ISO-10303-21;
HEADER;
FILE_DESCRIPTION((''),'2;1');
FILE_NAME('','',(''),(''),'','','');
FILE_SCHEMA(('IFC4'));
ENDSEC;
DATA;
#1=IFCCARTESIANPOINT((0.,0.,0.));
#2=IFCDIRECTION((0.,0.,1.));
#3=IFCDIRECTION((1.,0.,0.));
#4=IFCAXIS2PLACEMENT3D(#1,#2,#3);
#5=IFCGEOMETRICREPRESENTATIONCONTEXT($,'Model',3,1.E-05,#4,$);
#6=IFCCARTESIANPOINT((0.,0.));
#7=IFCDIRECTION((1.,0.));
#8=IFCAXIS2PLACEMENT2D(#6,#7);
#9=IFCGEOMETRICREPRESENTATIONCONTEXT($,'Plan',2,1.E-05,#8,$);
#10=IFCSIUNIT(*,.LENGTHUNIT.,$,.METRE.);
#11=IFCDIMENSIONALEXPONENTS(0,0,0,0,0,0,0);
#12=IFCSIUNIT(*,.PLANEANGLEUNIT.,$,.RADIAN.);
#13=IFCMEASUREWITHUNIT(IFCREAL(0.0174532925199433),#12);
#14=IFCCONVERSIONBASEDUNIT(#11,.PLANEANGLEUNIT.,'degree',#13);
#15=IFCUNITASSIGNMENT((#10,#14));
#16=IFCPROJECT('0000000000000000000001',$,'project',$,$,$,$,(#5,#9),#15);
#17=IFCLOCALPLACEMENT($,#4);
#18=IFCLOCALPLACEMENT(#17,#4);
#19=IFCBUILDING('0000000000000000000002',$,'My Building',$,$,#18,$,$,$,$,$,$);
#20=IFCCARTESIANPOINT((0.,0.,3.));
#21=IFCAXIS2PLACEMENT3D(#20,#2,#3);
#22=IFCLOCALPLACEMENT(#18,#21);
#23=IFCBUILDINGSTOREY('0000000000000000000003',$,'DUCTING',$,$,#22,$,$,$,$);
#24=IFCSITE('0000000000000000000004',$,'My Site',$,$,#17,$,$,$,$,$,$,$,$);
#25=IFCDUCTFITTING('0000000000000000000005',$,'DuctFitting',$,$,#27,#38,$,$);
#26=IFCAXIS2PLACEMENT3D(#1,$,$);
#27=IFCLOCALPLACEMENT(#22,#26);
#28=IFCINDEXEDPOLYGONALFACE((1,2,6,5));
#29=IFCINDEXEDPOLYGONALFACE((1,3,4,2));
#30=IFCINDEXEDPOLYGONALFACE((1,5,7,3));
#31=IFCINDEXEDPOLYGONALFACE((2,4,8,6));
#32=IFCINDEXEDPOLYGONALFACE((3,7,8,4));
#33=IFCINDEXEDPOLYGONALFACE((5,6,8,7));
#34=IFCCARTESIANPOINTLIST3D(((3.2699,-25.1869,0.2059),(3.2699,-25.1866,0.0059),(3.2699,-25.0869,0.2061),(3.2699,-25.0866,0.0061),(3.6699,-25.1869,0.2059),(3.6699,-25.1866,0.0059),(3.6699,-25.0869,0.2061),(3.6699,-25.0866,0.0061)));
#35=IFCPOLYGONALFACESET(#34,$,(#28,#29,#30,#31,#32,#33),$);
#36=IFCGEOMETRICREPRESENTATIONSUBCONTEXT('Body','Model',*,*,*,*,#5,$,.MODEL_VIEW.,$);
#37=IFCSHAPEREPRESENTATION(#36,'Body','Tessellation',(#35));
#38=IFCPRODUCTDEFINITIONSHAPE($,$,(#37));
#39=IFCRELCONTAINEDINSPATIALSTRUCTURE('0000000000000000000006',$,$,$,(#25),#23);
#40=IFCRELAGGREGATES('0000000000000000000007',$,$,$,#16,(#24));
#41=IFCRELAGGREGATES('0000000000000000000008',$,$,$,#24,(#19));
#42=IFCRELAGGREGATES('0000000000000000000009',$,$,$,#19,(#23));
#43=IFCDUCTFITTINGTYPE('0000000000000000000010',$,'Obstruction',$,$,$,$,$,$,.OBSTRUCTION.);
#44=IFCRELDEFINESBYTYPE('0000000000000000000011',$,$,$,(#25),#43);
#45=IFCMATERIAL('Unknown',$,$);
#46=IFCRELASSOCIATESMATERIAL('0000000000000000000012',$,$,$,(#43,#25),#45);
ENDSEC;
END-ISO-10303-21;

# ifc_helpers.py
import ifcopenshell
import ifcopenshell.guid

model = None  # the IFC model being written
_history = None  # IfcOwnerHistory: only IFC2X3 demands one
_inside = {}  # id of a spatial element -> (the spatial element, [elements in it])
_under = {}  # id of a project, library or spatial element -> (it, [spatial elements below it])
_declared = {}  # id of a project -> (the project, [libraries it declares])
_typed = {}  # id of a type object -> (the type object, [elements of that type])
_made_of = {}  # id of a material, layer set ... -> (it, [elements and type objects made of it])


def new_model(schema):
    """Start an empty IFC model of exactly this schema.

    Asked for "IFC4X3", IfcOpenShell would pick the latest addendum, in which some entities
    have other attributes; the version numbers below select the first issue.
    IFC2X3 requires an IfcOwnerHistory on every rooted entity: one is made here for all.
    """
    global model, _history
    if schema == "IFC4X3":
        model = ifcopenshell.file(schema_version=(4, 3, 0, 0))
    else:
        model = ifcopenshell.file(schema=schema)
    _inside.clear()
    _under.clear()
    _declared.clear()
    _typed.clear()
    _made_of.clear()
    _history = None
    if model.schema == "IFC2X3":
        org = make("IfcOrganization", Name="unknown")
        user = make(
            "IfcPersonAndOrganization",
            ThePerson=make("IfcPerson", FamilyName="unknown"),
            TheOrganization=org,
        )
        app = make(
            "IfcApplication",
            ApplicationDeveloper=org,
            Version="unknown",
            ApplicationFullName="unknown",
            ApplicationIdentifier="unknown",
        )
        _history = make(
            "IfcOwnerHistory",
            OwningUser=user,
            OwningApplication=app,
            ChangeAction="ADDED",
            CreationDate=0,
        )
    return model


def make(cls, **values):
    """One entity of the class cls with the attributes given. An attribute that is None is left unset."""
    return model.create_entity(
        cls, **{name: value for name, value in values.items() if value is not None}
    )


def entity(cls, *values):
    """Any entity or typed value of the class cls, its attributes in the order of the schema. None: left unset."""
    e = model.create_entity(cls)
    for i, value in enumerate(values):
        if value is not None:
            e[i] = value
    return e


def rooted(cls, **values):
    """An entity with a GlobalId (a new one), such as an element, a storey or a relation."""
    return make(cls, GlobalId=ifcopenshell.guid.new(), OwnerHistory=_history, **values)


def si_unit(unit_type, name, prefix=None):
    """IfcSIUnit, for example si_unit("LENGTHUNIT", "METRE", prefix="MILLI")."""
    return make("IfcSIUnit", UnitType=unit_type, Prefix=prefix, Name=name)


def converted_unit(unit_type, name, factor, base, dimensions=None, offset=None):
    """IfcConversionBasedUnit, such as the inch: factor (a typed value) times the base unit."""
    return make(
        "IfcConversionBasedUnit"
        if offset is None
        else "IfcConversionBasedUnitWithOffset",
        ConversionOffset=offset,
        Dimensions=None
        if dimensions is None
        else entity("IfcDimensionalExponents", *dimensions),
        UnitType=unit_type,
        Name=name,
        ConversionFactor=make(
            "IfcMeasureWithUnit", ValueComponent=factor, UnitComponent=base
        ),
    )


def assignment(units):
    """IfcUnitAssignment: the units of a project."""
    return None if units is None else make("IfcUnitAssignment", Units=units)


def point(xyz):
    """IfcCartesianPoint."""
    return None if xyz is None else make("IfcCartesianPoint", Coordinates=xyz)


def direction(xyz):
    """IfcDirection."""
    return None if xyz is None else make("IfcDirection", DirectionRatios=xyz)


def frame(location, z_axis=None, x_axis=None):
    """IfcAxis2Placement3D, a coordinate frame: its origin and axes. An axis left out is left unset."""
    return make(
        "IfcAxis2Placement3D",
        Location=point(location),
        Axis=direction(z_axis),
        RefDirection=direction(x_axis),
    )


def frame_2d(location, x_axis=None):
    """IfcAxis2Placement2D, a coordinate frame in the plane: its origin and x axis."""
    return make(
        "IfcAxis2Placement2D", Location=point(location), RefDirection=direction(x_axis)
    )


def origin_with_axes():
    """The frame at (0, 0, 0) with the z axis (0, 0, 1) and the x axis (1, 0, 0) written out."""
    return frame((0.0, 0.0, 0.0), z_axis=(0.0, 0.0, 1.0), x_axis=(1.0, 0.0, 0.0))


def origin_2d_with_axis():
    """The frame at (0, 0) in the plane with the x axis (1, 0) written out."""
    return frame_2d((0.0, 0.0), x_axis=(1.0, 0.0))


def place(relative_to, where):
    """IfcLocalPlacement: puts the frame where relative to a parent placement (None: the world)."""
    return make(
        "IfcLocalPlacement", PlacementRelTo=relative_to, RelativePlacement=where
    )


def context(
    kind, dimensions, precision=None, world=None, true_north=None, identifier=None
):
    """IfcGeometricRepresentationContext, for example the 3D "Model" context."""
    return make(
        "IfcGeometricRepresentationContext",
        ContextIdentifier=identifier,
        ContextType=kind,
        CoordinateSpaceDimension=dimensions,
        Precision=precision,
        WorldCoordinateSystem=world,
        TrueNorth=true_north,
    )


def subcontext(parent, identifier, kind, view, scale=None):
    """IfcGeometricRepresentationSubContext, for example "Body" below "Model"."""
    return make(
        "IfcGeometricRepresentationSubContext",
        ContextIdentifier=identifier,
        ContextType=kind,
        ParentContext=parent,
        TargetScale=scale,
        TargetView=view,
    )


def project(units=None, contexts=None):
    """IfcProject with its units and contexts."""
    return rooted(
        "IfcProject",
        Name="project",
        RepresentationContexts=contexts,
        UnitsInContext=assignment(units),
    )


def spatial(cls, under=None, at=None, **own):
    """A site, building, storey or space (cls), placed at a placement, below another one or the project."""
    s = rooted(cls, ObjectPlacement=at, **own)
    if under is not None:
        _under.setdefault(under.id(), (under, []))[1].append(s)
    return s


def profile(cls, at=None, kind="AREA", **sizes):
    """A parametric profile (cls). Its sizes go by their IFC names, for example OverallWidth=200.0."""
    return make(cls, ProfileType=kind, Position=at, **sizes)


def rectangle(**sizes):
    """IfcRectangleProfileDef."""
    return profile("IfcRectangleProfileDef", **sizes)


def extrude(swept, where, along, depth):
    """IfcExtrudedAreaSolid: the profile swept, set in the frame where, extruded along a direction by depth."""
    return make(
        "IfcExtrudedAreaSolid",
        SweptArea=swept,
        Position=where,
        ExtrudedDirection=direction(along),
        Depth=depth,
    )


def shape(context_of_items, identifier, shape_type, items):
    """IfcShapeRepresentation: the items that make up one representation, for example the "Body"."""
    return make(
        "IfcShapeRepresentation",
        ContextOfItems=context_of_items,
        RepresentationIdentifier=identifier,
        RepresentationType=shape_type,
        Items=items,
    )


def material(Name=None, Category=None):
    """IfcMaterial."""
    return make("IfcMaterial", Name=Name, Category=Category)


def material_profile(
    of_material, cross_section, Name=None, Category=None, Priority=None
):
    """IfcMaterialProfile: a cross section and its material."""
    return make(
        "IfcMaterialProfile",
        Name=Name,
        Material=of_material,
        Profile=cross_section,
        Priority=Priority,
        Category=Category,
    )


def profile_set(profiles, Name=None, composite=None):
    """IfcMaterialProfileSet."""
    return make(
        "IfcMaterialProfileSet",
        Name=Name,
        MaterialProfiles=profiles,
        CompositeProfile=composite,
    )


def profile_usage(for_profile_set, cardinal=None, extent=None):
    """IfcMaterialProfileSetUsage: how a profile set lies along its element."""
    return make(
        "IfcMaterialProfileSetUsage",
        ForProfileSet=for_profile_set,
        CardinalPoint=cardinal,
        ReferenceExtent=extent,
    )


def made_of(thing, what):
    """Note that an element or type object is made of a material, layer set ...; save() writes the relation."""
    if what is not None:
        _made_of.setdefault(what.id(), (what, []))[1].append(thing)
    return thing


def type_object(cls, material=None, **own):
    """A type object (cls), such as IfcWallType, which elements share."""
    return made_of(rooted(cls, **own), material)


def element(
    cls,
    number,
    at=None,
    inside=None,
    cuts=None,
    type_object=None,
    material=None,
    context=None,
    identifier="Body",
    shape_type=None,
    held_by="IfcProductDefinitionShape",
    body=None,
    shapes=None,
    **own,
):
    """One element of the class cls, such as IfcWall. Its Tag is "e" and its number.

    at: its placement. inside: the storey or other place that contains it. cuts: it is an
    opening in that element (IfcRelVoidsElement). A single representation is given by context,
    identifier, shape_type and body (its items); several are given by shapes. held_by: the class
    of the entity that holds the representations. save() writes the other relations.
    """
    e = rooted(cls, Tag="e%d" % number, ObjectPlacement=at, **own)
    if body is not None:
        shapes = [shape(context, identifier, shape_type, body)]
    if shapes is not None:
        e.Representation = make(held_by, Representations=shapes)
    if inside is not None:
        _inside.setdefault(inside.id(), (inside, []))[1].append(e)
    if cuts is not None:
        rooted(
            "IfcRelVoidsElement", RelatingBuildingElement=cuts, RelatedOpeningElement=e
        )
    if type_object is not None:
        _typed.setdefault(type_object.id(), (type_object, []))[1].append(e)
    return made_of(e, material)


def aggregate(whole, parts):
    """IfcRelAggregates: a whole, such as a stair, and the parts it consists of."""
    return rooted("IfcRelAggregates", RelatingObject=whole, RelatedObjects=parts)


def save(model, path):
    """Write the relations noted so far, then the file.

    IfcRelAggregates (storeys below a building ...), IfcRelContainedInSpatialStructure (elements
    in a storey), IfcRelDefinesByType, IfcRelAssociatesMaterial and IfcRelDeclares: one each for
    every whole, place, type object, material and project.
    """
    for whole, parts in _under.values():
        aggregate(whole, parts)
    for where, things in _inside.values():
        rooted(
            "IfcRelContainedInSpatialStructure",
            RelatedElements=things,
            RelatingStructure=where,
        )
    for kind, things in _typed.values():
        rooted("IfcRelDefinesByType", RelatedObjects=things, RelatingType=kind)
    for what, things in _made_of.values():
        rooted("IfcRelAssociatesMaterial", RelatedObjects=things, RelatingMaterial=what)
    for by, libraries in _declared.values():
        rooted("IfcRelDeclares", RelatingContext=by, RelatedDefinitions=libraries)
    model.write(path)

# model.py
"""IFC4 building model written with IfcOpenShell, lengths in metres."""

from ifc_helpers import new_model, entity, si_unit, converted_unit, frame, origin_with_axes, origin_2d_with_axis, place, context, subcontext, project, spatial, rectangle, extrude, material, material_profile, profile_set, profile_usage, type_object, element, save


model = new_model("IFC4")

# Units and contexts
model_context = context("Model", 3, precision=1e-05, world=origin_with_axes())
plan_context = context("Plan", 2, precision=1e-05, world=origin_2d_with_axis())
body_context = subcontext(model_context, "Body", "Model", "MODEL_VIEW")
ifc_project = project(units=[si_unit("LENGTHUNIT", "METRE"), converted_unit("PLANEANGLEUNIT", "degree", entity("IfcReal", 0.0174532925199433), si_unit("PLANEANGLEUNIT", "RADIAN"), dimensions=[0, 0, 0, 0, 0, 0, 0])], contexts=[model_context, plan_context])

# Site, building, storey
site_placement = place(None, origin_with_axes())
site = spatial("IfcSite", under=ifc_project, at=site_placement, Name="My Site")
building_placement = place(site_placement, origin_with_axes())
building = spatial("IfcBuilding", under=site, at=building_placement, Name="My Building")
storey_placement = place(building_placement, frame((0.0, 0.0, 3.0), z_axis=(0.0, 0.0, 1.0), x_axis=(1.0, 0.0, 0.0)))
storey = spatial("IfcBuildingStorey", under=building, at=storey_placement, Name="DUCTING")

# Shared definitions
ifc_material = material(Name="Unknown")

# Duct fitting
ifc_material_profile_1 = material_profile(ifc_material, rectangle(XDim=0.4, YDim=0.2))
ifc_profile_set_1 = profile_set([ifc_material_profile_1])
duct_fitting_type_1 = type_object("IfcDuctFittingType", Name="Obstruction", PredefinedType="OBSTRUCTION", material=ifc_profile_set_1)
ifc_profile_usage_1 = profile_usage(ifc_profile_set_1, cardinal=5)
duct_fitting_1_placement = place(storey_placement, frame((3.4699, -25.0867, 0.1061), z_axis=(0.0, -0.999998, -0.001745), x_axis=(1.0, 0.0, 0.0)))
element("IfcDuctFitting", 1, at=duct_fitting_1_placement, inside=storey, type_object=duct_fitting_type_1, material=ifc_profile_usage_1, Name="DuctFitting", context=body_context, shape_type="SweptSolid", body=[
    extrude(rectangle(XDim=0.4, YDim=0.2), origin_with_axes(), (0.0, 0.0, 1.0), 0.1),
])

save(model, "model.ifc")
